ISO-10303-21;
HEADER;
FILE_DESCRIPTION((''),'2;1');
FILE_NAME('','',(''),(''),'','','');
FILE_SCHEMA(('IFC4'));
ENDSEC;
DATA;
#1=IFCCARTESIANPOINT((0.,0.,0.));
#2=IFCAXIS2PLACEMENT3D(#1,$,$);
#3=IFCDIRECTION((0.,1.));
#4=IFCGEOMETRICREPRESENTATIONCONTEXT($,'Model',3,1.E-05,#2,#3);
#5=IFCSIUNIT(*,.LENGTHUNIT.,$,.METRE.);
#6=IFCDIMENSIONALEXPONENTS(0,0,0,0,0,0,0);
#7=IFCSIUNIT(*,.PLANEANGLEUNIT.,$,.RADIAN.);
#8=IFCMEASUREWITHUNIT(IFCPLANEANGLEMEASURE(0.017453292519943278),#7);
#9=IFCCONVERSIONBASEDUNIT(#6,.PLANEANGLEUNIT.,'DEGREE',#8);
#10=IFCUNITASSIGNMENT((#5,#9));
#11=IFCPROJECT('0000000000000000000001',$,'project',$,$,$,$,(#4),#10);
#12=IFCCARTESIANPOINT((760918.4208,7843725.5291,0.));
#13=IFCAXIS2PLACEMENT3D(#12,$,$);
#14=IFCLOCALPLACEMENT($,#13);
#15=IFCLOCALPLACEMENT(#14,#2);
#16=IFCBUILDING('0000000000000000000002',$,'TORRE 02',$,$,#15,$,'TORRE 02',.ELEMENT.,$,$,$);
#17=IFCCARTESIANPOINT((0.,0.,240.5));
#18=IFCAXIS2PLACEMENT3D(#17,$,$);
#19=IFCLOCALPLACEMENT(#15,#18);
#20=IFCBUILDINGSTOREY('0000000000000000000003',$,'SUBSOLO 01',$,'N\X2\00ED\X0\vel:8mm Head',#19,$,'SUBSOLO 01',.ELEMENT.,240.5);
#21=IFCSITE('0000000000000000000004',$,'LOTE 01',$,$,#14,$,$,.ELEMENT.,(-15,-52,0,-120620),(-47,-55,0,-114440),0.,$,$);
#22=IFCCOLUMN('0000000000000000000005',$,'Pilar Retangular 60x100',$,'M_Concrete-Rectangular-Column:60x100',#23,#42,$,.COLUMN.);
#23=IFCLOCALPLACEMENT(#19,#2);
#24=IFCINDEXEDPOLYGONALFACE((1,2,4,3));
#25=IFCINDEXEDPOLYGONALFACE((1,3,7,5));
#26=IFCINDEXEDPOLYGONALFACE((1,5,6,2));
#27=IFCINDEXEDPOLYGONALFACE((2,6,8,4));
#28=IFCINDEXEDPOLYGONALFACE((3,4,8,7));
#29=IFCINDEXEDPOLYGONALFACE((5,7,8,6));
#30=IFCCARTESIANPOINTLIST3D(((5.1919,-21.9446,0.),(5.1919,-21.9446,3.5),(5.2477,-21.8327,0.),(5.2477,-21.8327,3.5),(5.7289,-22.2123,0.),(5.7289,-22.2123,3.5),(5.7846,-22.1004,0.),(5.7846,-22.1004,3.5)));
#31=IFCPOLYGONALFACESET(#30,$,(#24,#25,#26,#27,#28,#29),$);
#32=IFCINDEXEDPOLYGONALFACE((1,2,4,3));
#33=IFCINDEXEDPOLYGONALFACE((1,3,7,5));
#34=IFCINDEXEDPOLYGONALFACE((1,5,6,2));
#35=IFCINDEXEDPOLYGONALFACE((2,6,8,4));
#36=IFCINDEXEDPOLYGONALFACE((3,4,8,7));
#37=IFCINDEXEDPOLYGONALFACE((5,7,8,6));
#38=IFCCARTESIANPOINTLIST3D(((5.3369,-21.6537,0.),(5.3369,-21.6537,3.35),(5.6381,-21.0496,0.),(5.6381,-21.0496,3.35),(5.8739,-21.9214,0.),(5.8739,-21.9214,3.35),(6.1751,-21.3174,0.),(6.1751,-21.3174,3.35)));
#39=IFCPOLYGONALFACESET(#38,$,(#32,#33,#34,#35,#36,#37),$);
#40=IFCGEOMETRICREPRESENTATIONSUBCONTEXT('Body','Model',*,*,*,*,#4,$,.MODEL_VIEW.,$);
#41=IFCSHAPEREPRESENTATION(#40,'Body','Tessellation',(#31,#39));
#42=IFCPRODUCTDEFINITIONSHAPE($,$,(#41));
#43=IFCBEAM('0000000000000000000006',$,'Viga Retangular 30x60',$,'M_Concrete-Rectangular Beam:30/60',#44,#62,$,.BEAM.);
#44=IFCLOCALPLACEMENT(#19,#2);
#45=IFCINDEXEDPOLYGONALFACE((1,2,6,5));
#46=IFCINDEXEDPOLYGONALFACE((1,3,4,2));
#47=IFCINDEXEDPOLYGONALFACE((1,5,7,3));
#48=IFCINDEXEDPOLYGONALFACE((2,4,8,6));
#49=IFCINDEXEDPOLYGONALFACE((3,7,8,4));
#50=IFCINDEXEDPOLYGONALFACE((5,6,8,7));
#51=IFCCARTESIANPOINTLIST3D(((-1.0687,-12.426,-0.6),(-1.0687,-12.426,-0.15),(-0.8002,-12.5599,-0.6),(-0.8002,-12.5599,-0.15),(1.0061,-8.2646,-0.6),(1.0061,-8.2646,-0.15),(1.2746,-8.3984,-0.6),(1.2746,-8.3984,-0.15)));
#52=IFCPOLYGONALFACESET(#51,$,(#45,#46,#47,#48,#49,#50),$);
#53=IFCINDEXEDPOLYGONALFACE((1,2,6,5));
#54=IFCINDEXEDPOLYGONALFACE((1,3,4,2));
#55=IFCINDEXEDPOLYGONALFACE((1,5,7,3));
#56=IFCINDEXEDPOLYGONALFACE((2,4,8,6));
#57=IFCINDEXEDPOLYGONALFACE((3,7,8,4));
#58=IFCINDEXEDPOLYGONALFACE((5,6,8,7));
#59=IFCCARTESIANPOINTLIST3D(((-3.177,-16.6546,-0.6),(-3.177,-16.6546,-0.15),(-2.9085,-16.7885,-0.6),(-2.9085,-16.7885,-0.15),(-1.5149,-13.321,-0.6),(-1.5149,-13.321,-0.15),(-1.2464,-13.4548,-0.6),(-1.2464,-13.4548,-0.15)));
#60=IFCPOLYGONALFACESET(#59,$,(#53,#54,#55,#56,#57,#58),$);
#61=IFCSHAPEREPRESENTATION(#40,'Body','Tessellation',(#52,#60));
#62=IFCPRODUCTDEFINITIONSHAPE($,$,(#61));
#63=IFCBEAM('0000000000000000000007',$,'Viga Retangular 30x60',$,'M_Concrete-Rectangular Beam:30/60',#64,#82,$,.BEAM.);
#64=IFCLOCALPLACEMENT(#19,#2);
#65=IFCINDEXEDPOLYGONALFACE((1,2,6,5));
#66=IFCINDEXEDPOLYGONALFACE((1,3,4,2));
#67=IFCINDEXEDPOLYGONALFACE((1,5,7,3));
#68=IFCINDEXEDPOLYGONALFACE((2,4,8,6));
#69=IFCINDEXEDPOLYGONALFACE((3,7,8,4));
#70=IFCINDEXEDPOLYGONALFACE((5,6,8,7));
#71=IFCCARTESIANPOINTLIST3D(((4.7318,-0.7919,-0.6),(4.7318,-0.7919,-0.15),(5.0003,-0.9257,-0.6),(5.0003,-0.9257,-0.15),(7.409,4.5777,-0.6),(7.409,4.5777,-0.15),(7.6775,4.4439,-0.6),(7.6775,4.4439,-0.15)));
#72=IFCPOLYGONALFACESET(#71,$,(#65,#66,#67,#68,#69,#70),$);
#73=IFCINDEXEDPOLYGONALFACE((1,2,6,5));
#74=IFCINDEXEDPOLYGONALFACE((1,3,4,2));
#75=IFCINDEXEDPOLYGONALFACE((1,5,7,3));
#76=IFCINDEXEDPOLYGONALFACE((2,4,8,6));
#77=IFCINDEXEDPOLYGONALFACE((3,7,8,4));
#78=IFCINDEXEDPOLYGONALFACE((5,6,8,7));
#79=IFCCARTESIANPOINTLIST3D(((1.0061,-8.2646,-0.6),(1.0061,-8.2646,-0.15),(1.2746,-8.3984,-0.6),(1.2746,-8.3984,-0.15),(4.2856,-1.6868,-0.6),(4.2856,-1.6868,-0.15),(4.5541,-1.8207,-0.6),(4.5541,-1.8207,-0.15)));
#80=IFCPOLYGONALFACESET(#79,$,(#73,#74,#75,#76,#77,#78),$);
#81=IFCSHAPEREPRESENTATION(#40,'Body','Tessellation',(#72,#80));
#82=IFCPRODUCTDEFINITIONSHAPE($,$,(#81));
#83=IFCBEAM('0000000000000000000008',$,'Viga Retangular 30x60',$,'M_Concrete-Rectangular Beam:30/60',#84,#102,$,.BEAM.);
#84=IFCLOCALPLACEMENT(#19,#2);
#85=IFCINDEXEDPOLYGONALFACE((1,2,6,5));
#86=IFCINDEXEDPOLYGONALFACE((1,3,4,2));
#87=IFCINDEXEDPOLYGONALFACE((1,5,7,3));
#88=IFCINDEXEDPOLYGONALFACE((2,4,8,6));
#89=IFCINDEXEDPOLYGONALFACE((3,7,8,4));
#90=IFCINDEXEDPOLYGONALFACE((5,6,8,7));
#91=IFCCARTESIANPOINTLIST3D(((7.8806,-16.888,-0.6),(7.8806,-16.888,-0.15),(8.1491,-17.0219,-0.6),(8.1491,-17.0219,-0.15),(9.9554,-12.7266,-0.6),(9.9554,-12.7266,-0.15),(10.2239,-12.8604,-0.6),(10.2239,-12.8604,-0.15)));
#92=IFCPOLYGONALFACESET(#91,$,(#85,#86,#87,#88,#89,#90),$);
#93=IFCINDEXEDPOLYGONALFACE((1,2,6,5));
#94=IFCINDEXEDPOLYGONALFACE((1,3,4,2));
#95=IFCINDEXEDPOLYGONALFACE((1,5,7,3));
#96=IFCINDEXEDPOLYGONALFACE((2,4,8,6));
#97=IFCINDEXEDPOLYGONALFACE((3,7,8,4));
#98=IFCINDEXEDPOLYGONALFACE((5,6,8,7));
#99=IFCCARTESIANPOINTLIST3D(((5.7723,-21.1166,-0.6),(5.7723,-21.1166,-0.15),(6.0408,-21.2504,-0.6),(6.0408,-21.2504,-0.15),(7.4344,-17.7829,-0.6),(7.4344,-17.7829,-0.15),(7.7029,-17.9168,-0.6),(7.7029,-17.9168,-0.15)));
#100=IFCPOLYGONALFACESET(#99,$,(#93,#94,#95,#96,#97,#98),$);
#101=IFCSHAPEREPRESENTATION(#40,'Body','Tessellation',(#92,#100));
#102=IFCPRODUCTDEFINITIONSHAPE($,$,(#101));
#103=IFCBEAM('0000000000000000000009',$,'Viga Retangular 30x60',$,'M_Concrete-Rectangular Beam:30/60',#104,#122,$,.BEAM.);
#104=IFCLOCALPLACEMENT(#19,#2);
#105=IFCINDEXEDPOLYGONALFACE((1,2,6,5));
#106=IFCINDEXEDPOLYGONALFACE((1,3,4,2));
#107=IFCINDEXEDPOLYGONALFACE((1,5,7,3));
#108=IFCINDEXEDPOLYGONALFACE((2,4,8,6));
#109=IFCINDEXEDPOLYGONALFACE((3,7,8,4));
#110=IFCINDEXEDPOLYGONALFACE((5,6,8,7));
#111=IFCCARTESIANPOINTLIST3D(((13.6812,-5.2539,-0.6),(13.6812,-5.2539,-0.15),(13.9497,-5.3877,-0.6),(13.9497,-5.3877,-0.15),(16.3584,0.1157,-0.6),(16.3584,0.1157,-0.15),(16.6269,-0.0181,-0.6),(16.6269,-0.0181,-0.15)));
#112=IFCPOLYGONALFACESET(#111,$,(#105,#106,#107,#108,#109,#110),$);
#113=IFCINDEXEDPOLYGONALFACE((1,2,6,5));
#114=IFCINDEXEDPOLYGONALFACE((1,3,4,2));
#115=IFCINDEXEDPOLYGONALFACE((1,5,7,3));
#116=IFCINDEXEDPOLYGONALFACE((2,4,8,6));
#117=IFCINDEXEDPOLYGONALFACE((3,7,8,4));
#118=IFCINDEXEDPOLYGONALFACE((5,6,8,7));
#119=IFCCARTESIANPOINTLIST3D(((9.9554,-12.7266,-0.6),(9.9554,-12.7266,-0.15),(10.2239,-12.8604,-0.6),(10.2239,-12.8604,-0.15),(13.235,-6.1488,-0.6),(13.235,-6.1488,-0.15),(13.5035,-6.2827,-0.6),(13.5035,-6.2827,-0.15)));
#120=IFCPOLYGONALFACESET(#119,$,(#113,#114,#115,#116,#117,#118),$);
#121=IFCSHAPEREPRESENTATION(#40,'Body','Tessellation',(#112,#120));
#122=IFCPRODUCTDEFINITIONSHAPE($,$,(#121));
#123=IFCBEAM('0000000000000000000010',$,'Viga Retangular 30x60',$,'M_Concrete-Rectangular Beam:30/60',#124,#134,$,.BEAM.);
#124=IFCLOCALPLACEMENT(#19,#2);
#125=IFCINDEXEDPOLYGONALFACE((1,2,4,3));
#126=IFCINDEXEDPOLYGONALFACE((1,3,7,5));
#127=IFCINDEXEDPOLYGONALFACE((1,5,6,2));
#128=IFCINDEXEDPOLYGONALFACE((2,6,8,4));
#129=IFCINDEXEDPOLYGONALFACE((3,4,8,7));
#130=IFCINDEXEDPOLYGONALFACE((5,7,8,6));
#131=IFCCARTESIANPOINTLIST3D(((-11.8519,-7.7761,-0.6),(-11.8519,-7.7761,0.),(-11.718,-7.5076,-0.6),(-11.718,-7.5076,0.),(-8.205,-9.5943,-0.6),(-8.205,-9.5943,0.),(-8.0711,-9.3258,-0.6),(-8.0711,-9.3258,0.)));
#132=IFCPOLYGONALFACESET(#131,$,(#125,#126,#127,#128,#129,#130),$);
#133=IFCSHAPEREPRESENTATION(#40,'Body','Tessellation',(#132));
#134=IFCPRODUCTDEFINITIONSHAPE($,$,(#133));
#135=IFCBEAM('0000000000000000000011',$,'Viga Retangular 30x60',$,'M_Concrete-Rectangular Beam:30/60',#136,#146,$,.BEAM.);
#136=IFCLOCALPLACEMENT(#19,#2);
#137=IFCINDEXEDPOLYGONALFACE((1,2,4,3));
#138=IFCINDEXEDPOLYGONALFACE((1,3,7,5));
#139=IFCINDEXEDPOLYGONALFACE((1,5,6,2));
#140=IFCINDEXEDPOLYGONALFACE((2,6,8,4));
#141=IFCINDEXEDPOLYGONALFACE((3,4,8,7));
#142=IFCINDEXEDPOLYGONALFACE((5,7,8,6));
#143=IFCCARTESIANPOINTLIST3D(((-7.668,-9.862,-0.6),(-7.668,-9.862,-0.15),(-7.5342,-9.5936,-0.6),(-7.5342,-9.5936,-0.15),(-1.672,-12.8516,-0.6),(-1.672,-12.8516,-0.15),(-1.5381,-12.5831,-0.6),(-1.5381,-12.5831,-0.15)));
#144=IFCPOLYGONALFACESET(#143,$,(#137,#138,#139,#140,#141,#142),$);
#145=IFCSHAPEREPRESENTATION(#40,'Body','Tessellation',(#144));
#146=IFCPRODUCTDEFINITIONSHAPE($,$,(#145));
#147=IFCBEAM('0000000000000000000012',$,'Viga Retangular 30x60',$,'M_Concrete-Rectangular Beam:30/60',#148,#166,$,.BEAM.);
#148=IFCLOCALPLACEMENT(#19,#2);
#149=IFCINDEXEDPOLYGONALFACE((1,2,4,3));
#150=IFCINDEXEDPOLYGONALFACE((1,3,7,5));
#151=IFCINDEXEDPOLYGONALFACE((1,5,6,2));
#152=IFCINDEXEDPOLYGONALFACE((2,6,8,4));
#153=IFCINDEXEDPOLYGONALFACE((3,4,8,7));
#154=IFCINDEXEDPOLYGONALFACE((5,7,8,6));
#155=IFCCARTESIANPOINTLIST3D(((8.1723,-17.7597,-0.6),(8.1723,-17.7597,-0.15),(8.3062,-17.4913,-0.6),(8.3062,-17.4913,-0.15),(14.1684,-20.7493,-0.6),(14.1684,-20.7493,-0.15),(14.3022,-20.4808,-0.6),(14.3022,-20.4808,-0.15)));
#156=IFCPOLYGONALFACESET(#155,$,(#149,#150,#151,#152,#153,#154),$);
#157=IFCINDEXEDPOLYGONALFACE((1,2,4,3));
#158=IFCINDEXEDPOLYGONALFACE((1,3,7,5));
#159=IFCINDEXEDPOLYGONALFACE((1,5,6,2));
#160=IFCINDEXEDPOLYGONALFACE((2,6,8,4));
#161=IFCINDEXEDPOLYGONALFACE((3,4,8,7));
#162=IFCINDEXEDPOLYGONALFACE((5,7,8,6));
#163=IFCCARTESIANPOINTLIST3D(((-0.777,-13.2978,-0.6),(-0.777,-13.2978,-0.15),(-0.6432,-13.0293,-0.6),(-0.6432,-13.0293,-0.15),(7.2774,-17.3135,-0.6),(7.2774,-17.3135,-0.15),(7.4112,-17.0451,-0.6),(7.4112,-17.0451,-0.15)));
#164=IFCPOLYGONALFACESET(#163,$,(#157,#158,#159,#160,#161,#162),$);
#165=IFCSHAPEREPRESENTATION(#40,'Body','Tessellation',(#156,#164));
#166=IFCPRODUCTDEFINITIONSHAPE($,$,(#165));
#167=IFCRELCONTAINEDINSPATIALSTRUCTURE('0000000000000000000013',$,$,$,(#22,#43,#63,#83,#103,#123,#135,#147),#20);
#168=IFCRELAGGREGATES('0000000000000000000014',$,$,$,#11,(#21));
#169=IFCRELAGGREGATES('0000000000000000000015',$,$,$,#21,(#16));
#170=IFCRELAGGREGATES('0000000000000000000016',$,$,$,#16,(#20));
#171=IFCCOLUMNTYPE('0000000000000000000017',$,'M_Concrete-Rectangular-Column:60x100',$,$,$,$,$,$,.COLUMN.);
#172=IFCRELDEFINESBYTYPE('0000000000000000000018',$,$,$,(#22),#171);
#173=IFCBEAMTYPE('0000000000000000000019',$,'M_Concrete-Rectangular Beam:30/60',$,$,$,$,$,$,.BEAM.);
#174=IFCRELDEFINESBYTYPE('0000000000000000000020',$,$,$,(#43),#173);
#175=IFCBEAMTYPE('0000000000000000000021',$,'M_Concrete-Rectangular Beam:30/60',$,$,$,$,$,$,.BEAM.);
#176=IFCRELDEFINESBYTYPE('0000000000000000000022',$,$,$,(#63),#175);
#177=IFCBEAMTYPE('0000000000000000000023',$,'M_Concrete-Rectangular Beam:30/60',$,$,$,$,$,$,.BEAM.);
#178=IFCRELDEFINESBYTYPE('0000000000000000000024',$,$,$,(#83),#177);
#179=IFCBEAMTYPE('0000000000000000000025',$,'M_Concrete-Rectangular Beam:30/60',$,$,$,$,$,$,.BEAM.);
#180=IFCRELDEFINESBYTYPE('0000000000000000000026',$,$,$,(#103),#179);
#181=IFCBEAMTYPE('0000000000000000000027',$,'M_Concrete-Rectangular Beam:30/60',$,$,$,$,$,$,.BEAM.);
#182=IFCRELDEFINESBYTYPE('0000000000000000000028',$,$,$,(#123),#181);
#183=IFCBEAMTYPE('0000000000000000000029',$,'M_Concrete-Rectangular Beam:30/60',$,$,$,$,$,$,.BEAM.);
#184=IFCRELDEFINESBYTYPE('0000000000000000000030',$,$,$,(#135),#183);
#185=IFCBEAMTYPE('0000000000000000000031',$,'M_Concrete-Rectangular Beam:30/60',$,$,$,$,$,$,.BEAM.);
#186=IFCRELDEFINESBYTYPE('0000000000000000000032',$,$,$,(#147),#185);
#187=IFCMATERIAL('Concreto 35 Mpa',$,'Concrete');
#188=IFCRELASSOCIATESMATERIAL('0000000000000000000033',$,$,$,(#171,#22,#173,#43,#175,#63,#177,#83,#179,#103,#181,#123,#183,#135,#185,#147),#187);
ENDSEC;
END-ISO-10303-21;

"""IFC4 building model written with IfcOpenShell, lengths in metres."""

from ifc_helpers import new_model, entity, si_unit, converted_unit, direction, frame, origin, place, context, subcontext, project, spatial, indexed_curve, outline, extrude, source, transform, mapped, material, type_object, type_shapes, element, save


model = new_model("IFC4")

# Units and contexts
model_context = context("Model", 3, precision=1e-05, world=origin(), true_north=direction((0.0, 1.0)))
body_context = subcontext(model_context, "Body", "Model", "MODEL_VIEW")
ifc_project = project(units=[si_unit("LENGTHUNIT", "METRE"), converted_unit("PLANEANGLEUNIT", "DEGREE", entity("IfcPlaneAngleMeasure", 0.017453292519943278), si_unit("PLANEANGLEUNIT", "RADIAN"), dimensions=[0, 0, 0, 0, 0, 0, 0])], contexts=[model_context])

# Site, building, storey
site_placement = place(None, frame((760918.4208, 7843725.5291, 0.0)))
site = spatial("IfcSite", under=ifc_project, at=site_placement, Name="LOTE 01", CompositionType="ELEMENT", RefLatitude=(-15, -52, 0, -120620), RefLongitude=(-47, -55, 0, -114440), RefElevation=0.0)
building_placement = place(site_placement, origin())
building = spatial("IfcBuilding", under=site, at=building_placement, Name="TORRE 02", LongName="TORRE 02", CompositionType="ELEMENT")
storey_placement = place(building_placement, frame((0.0, 0.0, 240.5)))
storey = spatial("IfcBuildingStorey", under=building, at=storey_placement, Name="SUBSOLO 01", ObjectType="Nível:8mm Head", LongName="SUBSOLO 01", CompositionType="ELEMENT", Elevation=240.5)

# Column
ifc_material = material(Name="Concreto 35 Mpa", Category="Concrete")
column_type_1 = type_object("IfcColumnType", Name="M_Concrete-Rectangular-Column:60x100", PredefinedType="COLUMN", material=ifc_material)
shared_shape_1 = source(origin(), body_context, "Body", "SweptSolid", [
    extrude(outline(indexed_curve([(-0.0625, -0.3), (0.0625, -0.3), (0.0625, 0.3), (-0.0625, 0.3), (-0.0625, -0.3)], self_intersect=False)), frame((5.4883, -22.0225, 240.5), z_axis=(0.0, 0.0, 1.0), x_axis=(0.446198, 0.894934, 0.0)), (0.0, 0.0, 1.0), 3.5),
    extrude(outline(indexed_curve([(-1.675, -0.3375), (1.675, -0.3375), (1.675, 0.3375), (-1.675, 0.3375), (-1.675, -0.3375)], self_intersect=False)), frame((5.4875, -21.3517, 242.175), z_axis=(0.894934, -0.446198, 0.0), x_axis=(0.0, 0.0, 1.0)), (0.0, 0.0, 1.0), 0.6),
])
type_shapes(column_type_1, [shared_shape_1])
column_1_placement = place(storey_placement, frame((0.0, 0.0, -240.5)))
element("IfcColumn", 1, at=column_1_placement, inside=storey, type_object=column_type_1, material=ifc_material, Name="Pilar Retangular 60x100", ObjectType="M_Concrete-Rectangular-Column:60x100", PredefinedType="COLUMN", context=body_context, shape_type="MappedRepresentation", body=[
    mapped(shared_shape_1, transform((0.0, 0.0, 0.0), scale=1.0)),
])

# Beams
beam_type_1 = type_object("IfcBeamType", Name="M_Concrete-Rectangular Beam:30/60", PredefinedType="BEAM", material=ifc_material)
shared_shape_2 = source(origin(), body_context, "Body", "SweptSolid", [
    extrude(outline(indexed_curve([(-0.225, -0.15), (0.225, -0.15), (0.225, 0.15), (-0.225, 0.15), (-0.225, -0.15)], self_intersect=False)), frame((-0.9345, -12.493, 240.125), z_axis=(0.446198, 0.894934, 0.0), x_axis=(0.0, 0.0, 1.0)), (0.0, 0.0, 1.0), 4.65),
    extrude(outline(indexed_curve([(-0.225, -0.15), (0.225, -0.15), (0.225, 0.15), (-0.225, 0.15), (-0.225, -0.15)], self_intersect=False)), frame((-3.0428, -16.7215, 240.125), z_axis=(0.446198, 0.894934, 0.0), x_axis=(0.0, 0.0, 1.0)), (0.0, 0.0, 1.0), 3.725),
])
type_shapes(beam_type_1, [shared_shape_2])
beam_1_placement = place(storey_placement, frame((0.0, 0.0, -240.5)))
element("IfcBeam", 2, at=beam_1_placement, inside=storey, type_object=beam_type_1, material=ifc_material, Name="Viga Retangular 30x60", ObjectType="M_Concrete-Rectangular Beam:30/60", PredefinedType="BEAM", context=body_context, shape_type="MappedRepresentation", body=[
    mapped(shared_shape_2, transform((0.0, 0.0, 0.0), scale=1.0)),
])
beam_type_2 = type_object("IfcBeamType", Name="M_Concrete-Rectangular Beam:30/60", PredefinedType="BEAM", material=ifc_material)
shared_shape_3 = source(origin(), body_context, "Body", "SweptSolid", [
    extrude(outline(indexed_curve([(-0.225, -0.15), (0.225, -0.15), (0.225, 0.15), (-0.225, 0.15), (-0.225, -0.15)], self_intersect=False)), frame((4.8661, -0.8588, 240.125), z_axis=(0.446198, 0.894934, 0.0), x_axis=(0.0, 0.0, 1.0)), (0.0, 0.0, 1.0), 6.0),
    extrude(outline(indexed_curve([(-0.225, -0.15), (0.225, -0.15), (0.225, 0.15), (-0.225, 0.15), (-0.225, -0.15)], self_intersect=False)), frame((1.1403, -8.3315, 240.125), z_axis=(0.446198, 0.894934, 0.0), x_axis=(0.0, 0.0, 1.0)), (0.0, 0.0, 1.0), 7.35),
])
type_shapes(beam_type_2, [shared_shape_3])
beam_2_placement = place(storey_placement, frame((0.0, 0.0, -240.5)))
element("IfcBeam", 3, at=beam_2_placement, inside=storey, type_object=beam_type_2, material=ifc_material, Name="Viga Retangular 30x60", ObjectType="M_Concrete-Rectangular Beam:30/60", PredefinedType="BEAM", context=body_context, shape_type="MappedRepresentation", body=[
    mapped(shared_shape_3, transform((0.0, 0.0, 0.0), scale=1.0)),
])
beam_type_3 = type_object("IfcBeamType", Name="M_Concrete-Rectangular Beam:30/60", PredefinedType="BEAM", material=ifc_material)
shared_shape_4 = source(origin(), body_context, "Body", "SweptSolid", [
    extrude(outline(indexed_curve([(-0.225, -0.15), (0.225, -0.15), (0.225, 0.15), (-0.225, 0.15), (-0.225, -0.15)], self_intersect=False)), frame((8.0149, -16.9549, 240.125), z_axis=(0.446198, 0.894934, 0.0), x_axis=(0.0, 0.0, 1.0)), (0.0, 0.0, 1.0), 4.65),
    extrude(outline(indexed_curve([(-0.225, -0.15), (0.225, -0.15), (0.225, 0.15), (-0.225, 0.15), (-0.225, -0.15)], self_intersect=False)), frame((5.9066, -21.1835, 240.125), z_axis=(0.446198, 0.894934, 0.0), x_axis=(0.0, 0.0, 1.0)), (0.0, 0.0, 1.0), 3.725),
])
type_shapes(beam_type_3, [shared_shape_4])
beam_3_placement = place(storey_placement, frame((0.0, 0.0, -240.5)))
element("IfcBeam", 4, at=beam_3_placement, inside=storey, type_object=beam_type_3, material=ifc_material, Name="Viga Retangular 30x60", ObjectType="M_Concrete-Rectangular Beam:30/60", PredefinedType="BEAM", context=body_context, shape_type="MappedRepresentation", body=[
    mapped(shared_shape_4, transform((0.0, 0.0, 0.0), scale=1.0)),
])
beam_type_4 = type_object("IfcBeamType", Name="M_Concrete-Rectangular Beam:30/60", PredefinedType="BEAM", material=ifc_material)
shared_shape_5 = source(origin(), body_context, "Body", "SweptSolid", [
    extrude(outline(indexed_curve([(-0.225, -0.15), (0.225, -0.15), (0.225, 0.15), (-0.225, 0.15), (-0.225, -0.15)], self_intersect=False)), frame((13.8154, -5.3208, 240.125), z_axis=(0.446198, 0.894934, 0.0), x_axis=(0.0, 0.0, 1.0)), (0.0, 0.0, 1.0), 6.0),
    extrude(outline(indexed_curve([(-0.225, -0.15), (0.225, -0.15), (0.225, 0.15), (-0.225, 0.15), (-0.225, -0.15)], self_intersect=False)), frame((10.0897, -12.7935, 240.125), z_axis=(0.446198, 0.894934, 0.0), x_axis=(0.0, 0.0, 1.0)), (0.0, 0.0, 1.0), 7.35),
])
type_shapes(beam_type_4, [shared_shape_5])
beam_4_placement = place(storey_placement, frame((0.0, 0.0, -240.5)))
element("IfcBeam", 5, at=beam_4_placement, inside=storey, type_object=beam_type_4, material=ifc_material, Name="Viga Retangular 30x60", ObjectType="M_Concrete-Rectangular Beam:30/60", PredefinedType="BEAM", context=body_context, shape_type="MappedRepresentation", body=[
    mapped(shared_shape_5, transform((0.0, 0.0, 0.0), scale=1.0)),
])
beam_type_5 = type_object("IfcBeamType", Name="M_Concrete-Rectangular Beam:30/60", PredefinedType="BEAM", material=ifc_material)
shared_shape_6 = source(origin(), body_context, "Body", "SweptSolid", [
    extrude(outline(indexed_curve([(-0.3, -0.15), (0.3, -0.15), (0.3, 0.15), (-0.3, 0.15), (-0.3, -0.15)], self_intersect=False)), frame((-11.7849, -7.6418, 240.2), z_axis=(0.894934, -0.446198, 0.0), x_axis=(0.0, 0.0, -1.0)), (0.0, 0.0, 1.0), 4.075),
])
type_shapes(beam_type_5, [shared_shape_6])
beam_5_placement = place(storey_placement, frame((0.0, 0.0, -240.5)))
element("IfcBeam", 6, at=beam_5_placement, inside=storey, type_object=beam_type_5, material=ifc_material, Name="Viga Retangular 30x60", ObjectType="M_Concrete-Rectangular Beam:30/60", PredefinedType="BEAM", context=body_context, shape_type="MappedRepresentation", body=[
    mapped(shared_shape_6, transform((0.0, 0.0, 0.0), scale=1.0)),
])
beam_type_6 = type_object("IfcBeamType", Name="M_Concrete-Rectangular Beam:30/60", PredefinedType="BEAM", material=ifc_material)
shared_shape_7 = source(origin(), body_context, "Body", "SweptSolid", [
    extrude(outline(indexed_curve([(-0.225, -0.15), (0.225, -0.15), (0.225, 0.15), (-0.225, 0.15), (-0.225, -0.15)], self_intersect=False)), frame((-7.6011, -9.7278, 240.125), z_axis=(0.894934, -0.446198, 0.0), x_axis=(0.0, 0.0, -1.0)), (0.0, 0.0, 1.0), 6.7),
])
type_shapes(beam_type_6, [shared_shape_7])
beam_6_placement = place(storey_placement, frame((0.0, 0.0, -240.5)))
element("IfcBeam", 7, at=beam_6_placement, inside=storey, type_object=beam_type_6, material=ifc_material, Name="Viga Retangular 30x60", ObjectType="M_Concrete-Rectangular Beam:30/60", PredefinedType="BEAM", context=body_context, shape_type="MappedRepresentation", body=[
    mapped(shared_shape_7, transform((0.0, 0.0, 0.0), scale=1.0)),
])
beam_type_7 = type_object("IfcBeamType", Name="M_Concrete-Rectangular Beam:30/60", PredefinedType="BEAM", material=ifc_material)
shared_shape_8 = source(origin(), body_context, "Body", "SweptSolid", [
    extrude(outline(indexed_curve([(-0.225, -0.15), (0.225, -0.15), (0.225, 0.15), (-0.225, 0.15), (-0.225, -0.15)], self_intersect=False)), frame((8.2392, -17.6255, 240.125), z_axis=(0.894934, -0.446198, 0.0), x_axis=(0.0, 0.0, -1.0)), (0.0, 0.0, 1.0), 6.7),
    extrude(outline(indexed_curve([(-0.225, -0.15), (0.225, -0.15), (0.225, 0.15), (-0.225, 0.15), (-0.225, -0.15)], self_intersect=False)), frame((-0.7101, -13.1635, 240.125), z_axis=(0.894934, -0.446198, 0.0), x_axis=(0.0, 0.0, -1.0)), (0.0, 0.0, 1.0), 9.0),
])
type_shapes(beam_type_7, [shared_shape_8])
beam_7_placement = place(storey_placement, frame((0.0, 0.0, -240.5)))
element("IfcBeam", 8, at=beam_7_placement, inside=storey, type_object=beam_type_7, material=ifc_material, Name="Viga Retangular 30x60", ObjectType="M_Concrete-Rectangular Beam:30/60", PredefinedType="BEAM", context=body_context, shape_type="MappedRepresentation", body=[
    mapped(shared_shape_8, transform((0.0, 0.0, 0.0), scale=1.0)),
])

save(model, "model.ifc")
